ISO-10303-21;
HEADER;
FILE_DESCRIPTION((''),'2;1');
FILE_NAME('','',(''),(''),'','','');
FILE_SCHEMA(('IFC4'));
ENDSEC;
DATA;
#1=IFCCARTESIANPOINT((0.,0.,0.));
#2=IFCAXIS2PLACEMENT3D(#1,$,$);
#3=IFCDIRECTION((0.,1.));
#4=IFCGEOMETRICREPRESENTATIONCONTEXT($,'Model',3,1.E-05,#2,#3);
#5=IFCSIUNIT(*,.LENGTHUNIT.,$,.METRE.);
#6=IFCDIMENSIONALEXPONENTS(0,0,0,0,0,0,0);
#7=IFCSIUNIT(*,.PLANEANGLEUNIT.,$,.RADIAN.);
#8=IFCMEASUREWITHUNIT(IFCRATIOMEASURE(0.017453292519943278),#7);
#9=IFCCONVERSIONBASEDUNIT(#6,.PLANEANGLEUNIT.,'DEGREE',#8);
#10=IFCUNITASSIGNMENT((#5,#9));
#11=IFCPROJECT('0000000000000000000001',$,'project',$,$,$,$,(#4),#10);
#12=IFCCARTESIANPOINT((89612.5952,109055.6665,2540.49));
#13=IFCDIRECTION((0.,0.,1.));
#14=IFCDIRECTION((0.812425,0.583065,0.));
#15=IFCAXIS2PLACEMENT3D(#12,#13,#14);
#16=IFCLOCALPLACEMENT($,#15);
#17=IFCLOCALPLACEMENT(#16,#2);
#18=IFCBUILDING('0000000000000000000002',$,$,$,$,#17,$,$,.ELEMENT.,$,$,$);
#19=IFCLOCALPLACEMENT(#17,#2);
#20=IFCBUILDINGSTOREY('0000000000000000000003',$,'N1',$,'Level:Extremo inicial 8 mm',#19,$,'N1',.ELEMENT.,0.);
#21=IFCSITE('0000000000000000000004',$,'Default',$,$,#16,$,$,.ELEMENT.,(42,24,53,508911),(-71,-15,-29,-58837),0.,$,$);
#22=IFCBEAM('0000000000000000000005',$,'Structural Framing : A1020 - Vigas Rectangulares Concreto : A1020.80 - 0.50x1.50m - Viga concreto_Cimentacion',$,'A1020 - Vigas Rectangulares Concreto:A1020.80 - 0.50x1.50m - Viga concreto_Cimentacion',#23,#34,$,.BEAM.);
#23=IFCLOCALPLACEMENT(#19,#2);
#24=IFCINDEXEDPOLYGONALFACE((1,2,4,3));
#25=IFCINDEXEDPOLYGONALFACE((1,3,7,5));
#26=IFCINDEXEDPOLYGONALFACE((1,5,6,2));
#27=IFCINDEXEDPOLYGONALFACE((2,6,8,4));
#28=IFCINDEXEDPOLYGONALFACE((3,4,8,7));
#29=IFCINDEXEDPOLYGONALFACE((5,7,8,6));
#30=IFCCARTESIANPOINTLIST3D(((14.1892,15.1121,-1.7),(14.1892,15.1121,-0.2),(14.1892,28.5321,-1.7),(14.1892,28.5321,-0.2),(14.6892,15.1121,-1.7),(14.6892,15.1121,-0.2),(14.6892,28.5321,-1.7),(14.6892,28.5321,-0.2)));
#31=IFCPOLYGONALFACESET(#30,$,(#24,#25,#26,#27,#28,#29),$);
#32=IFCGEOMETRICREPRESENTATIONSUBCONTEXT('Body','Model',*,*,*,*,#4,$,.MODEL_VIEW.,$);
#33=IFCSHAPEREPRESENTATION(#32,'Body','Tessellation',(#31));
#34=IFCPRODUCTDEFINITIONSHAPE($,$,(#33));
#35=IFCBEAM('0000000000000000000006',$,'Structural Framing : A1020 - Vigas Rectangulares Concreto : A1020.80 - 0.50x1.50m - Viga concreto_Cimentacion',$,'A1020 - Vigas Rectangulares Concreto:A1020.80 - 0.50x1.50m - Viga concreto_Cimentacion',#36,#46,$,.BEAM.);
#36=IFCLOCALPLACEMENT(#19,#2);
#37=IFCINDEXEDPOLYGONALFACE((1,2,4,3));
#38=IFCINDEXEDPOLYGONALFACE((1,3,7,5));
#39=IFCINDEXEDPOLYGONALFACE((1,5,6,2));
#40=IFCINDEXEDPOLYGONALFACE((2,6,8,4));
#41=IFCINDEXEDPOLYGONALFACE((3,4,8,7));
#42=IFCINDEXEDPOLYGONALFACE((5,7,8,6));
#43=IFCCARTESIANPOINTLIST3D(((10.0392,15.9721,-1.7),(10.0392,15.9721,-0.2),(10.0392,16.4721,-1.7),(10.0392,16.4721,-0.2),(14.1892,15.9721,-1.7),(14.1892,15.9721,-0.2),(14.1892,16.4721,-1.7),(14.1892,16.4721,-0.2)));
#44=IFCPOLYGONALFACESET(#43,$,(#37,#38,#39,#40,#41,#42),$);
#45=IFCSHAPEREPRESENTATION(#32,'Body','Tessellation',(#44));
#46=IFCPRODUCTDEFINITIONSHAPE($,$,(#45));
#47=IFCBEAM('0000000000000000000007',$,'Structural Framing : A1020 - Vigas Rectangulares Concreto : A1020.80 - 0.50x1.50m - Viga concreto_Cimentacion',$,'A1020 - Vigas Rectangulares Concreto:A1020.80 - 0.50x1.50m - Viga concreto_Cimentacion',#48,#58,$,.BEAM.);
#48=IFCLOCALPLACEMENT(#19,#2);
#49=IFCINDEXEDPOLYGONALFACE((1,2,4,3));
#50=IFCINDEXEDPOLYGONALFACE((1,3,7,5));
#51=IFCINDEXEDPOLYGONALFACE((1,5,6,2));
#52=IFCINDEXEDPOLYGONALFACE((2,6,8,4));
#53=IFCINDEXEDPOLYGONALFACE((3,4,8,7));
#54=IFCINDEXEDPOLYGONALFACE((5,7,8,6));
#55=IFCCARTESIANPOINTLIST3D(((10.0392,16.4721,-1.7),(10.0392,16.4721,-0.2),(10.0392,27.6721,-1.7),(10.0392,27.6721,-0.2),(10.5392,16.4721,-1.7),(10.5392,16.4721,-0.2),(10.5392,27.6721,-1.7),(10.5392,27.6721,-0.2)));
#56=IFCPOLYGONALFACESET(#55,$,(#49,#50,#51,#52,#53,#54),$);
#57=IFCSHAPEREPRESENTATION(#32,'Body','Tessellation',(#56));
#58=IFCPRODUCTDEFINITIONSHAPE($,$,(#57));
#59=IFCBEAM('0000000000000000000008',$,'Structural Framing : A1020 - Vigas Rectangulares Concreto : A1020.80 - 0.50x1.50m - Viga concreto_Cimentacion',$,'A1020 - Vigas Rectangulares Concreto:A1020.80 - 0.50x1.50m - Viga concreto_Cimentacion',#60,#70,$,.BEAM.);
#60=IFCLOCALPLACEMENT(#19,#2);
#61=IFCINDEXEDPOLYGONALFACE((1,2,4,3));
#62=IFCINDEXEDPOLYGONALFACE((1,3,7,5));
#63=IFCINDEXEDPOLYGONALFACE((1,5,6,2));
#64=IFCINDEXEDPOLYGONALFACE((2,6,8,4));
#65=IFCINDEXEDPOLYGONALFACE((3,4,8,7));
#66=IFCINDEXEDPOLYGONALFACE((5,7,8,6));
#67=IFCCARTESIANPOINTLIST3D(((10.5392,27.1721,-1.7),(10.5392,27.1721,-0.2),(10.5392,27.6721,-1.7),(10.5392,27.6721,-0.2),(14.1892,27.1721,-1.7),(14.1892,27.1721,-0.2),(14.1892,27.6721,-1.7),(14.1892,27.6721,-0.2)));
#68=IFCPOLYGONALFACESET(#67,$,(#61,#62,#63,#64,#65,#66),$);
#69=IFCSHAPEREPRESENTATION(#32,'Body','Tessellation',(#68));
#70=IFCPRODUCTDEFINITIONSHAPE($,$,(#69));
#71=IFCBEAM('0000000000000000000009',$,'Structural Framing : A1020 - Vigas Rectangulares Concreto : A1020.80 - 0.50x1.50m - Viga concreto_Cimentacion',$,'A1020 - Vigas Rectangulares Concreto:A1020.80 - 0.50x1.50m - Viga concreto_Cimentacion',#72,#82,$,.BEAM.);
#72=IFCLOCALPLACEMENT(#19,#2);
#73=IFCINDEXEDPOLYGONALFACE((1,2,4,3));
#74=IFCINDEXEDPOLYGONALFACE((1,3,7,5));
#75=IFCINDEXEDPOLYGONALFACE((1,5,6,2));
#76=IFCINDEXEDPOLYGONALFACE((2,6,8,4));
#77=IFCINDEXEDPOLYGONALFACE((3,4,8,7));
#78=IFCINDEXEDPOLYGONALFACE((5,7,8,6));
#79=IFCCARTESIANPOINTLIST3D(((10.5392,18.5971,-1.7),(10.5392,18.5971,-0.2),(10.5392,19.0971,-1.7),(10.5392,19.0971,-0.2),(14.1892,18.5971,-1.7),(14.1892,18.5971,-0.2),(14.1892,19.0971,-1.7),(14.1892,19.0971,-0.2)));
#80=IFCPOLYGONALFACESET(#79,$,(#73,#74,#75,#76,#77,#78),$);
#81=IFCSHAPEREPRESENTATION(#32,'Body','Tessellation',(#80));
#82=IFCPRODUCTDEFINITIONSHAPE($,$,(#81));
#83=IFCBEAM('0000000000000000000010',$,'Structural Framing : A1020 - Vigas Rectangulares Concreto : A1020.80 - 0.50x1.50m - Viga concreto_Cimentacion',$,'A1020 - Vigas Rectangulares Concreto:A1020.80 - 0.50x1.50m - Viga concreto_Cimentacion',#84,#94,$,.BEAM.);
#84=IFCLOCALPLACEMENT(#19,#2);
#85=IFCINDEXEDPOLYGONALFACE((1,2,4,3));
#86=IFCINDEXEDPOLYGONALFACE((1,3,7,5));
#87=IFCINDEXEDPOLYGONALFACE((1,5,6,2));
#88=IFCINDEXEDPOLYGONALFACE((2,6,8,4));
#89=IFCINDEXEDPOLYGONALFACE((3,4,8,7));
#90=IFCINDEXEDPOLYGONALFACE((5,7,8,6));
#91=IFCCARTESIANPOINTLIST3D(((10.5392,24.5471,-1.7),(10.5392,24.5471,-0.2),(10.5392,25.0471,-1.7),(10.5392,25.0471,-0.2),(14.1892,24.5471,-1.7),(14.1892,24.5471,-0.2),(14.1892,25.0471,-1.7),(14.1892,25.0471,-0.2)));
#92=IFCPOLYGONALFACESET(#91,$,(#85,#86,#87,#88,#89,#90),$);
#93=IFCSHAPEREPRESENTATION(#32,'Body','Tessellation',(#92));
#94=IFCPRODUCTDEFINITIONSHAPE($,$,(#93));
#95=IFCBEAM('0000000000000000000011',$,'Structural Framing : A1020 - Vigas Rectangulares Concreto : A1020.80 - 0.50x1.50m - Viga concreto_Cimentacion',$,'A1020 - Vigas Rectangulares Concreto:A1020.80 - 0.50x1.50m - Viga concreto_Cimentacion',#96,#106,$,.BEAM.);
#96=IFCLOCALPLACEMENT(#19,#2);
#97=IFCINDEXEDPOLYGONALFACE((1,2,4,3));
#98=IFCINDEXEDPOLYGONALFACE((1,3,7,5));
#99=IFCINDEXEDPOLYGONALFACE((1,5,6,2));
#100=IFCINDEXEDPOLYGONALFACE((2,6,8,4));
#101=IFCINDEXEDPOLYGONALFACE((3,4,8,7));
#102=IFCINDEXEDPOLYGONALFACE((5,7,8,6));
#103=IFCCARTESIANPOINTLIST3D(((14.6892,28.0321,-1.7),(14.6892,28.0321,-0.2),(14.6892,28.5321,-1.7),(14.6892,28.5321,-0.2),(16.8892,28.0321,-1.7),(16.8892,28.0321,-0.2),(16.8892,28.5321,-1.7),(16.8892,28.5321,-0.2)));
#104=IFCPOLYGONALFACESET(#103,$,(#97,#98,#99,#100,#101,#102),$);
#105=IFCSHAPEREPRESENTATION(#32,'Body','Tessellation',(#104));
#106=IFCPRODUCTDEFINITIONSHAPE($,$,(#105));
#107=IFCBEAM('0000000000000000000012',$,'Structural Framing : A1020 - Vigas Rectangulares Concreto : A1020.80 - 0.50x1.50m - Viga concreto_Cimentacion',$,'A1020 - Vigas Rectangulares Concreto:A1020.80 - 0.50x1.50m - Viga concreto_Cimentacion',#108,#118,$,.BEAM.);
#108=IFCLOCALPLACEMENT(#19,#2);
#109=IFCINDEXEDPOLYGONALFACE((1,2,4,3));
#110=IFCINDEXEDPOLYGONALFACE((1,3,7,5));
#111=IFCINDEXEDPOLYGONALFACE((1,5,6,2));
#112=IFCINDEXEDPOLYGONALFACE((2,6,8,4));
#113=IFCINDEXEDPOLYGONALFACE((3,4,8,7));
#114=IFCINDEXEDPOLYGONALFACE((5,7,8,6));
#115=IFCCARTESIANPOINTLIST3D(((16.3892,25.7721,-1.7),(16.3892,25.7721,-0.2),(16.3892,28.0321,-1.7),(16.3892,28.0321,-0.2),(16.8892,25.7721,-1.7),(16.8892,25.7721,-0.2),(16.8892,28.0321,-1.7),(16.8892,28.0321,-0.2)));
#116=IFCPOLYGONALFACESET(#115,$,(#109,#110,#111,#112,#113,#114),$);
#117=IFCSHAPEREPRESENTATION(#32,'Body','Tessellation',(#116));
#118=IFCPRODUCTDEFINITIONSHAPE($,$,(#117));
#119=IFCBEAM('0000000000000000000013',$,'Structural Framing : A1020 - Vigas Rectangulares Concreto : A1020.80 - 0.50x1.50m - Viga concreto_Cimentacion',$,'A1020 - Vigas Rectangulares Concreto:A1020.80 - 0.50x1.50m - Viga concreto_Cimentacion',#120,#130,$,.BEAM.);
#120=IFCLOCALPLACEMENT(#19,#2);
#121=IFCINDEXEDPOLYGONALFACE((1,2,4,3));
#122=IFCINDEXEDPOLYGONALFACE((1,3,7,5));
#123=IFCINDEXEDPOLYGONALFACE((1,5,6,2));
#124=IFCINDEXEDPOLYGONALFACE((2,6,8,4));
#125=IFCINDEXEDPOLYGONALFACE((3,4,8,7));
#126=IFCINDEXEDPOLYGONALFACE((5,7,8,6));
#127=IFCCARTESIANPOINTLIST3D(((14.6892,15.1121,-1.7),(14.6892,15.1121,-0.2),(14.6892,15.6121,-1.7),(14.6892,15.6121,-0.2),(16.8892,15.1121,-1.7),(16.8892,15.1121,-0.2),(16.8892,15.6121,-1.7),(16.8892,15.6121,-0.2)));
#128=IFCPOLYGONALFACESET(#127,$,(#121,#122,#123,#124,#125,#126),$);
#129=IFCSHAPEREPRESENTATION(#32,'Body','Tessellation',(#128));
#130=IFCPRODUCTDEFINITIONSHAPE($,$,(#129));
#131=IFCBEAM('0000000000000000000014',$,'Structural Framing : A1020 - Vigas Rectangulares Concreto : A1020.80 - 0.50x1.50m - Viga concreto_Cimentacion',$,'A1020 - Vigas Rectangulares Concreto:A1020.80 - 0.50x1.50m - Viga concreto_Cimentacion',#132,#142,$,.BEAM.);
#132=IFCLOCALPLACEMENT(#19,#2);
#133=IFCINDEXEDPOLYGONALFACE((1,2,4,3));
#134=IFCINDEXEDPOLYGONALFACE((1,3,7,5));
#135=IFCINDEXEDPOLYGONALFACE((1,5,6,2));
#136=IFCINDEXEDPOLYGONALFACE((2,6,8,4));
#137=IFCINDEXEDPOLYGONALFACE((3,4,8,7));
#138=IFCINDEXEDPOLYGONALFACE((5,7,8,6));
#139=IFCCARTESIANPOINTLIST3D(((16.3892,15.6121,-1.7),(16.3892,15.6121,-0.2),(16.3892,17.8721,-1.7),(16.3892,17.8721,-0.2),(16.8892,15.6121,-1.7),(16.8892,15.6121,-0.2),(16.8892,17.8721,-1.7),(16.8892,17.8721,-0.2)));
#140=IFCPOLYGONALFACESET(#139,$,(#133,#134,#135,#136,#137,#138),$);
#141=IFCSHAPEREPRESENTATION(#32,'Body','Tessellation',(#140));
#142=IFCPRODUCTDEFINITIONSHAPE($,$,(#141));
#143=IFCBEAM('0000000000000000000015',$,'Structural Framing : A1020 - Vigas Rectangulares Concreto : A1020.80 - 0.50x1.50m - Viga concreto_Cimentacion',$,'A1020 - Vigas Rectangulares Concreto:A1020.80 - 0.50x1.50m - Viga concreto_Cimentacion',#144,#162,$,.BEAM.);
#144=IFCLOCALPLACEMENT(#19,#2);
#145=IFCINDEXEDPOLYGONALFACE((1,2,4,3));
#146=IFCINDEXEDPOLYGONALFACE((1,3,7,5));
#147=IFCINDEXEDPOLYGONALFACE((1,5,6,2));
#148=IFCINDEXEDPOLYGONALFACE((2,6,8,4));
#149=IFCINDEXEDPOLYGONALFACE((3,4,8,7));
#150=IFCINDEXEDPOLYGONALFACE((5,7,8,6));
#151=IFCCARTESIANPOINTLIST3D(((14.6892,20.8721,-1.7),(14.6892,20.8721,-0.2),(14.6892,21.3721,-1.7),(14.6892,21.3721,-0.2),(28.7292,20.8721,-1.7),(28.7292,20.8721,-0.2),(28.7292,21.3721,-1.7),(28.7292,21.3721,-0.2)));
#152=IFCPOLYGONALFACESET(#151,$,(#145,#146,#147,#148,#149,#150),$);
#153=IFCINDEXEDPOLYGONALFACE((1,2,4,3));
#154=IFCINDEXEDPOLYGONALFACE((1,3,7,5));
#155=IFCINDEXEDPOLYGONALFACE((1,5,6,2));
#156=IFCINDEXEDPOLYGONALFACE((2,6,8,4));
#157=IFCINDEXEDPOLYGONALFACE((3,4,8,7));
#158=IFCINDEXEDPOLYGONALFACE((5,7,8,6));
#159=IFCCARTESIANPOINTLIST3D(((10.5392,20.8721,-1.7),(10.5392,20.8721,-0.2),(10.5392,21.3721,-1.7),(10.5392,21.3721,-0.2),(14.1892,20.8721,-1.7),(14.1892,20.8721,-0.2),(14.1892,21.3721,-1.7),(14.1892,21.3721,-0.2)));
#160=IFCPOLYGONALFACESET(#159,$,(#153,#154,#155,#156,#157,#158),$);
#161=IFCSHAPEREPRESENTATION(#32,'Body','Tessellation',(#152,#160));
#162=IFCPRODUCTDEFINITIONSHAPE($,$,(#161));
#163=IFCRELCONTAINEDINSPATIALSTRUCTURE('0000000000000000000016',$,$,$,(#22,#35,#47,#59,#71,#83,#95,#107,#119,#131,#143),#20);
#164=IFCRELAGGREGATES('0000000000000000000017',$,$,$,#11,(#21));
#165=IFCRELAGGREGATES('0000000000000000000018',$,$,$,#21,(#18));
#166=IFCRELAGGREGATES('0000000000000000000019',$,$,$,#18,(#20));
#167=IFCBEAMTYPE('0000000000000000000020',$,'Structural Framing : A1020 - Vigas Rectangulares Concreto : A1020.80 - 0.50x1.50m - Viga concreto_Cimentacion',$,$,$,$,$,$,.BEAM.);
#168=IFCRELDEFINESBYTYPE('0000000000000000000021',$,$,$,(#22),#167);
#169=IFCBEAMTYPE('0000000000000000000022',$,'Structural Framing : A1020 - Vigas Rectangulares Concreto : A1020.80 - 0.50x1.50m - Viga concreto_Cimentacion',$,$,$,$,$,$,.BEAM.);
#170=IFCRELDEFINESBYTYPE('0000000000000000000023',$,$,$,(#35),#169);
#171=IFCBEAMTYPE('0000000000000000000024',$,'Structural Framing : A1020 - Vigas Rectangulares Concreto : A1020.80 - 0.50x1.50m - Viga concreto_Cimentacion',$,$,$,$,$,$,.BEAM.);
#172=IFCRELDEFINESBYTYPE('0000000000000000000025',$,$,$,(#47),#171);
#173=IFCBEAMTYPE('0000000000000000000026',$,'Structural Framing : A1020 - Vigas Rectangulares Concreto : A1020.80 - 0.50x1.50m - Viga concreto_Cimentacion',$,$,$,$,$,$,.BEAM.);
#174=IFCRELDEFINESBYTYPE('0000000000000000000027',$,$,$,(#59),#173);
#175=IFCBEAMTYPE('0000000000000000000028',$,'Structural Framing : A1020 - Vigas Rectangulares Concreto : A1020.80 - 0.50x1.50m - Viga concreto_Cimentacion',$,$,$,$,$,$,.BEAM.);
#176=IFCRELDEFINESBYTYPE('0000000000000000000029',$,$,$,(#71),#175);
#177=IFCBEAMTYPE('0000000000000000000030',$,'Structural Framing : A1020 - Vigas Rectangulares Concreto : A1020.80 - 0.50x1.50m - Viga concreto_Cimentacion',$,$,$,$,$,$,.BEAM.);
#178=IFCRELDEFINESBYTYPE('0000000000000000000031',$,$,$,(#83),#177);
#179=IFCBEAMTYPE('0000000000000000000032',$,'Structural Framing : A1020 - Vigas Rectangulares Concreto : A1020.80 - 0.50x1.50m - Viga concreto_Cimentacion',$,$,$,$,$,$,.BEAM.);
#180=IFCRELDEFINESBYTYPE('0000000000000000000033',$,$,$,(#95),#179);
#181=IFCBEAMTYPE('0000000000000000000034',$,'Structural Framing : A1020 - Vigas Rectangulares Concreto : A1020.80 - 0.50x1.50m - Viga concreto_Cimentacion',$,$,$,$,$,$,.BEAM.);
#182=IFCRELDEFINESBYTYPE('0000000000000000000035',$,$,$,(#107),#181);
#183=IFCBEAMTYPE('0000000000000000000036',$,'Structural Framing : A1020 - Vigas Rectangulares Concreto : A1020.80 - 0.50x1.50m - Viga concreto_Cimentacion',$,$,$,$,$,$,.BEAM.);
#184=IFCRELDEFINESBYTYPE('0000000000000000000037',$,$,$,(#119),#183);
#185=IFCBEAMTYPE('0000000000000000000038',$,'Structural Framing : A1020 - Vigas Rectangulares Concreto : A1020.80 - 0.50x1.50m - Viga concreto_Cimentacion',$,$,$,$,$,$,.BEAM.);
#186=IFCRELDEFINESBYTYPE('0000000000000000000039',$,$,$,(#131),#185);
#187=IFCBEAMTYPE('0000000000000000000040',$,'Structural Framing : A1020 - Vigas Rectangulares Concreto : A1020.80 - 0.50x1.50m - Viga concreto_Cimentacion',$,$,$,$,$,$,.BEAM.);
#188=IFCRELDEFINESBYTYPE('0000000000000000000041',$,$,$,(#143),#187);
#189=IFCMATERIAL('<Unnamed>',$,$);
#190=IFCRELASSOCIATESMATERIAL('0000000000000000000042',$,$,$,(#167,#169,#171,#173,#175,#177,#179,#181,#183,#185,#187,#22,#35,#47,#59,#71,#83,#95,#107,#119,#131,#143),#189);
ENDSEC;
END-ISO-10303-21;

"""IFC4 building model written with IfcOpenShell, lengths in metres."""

from ifc_helpers import new_model, entity, si_unit, converted_unit, direction, frame, frame_2d, origin, place, context, subcontext, project, spatial, polyline, segment, composite_curve, rectangle, outline, extrude, source, transform, mapped, material, material_profile, profile_set, profile_usage, type_object, type_shapes, element, save


model = new_model("IFC4")

# Units and contexts
model_context = context("Model", 3, precision=1e-05, world=origin(), true_north=direction((0.0, 1.0)))
body_context = subcontext(model_context, "Body", "Model", "MODEL_VIEW")
ifc_project = project(units=[si_unit("LENGTHUNIT", "METRE"), converted_unit("PLANEANGLEUNIT", "DEGREE", entity("IfcRatioMeasure", 0.017453292519943278), si_unit("PLANEANGLEUNIT", "RADIAN"), dimensions=[0, 0, 0, 0, 0, 0, 0])], contexts=[model_context])

# Site, building, storey
site_placement = place(None, frame((89612.5952, 109055.6665, 2540.49), z_axis=(0.0, 0.0, 1.0), x_axis=(0.812425, 0.583065, 0.0)))
site = spatial("IfcSite", under=ifc_project, at=site_placement, Name="Default", CompositionType="ELEMENT", RefLatitude=(42, 24, 53, 508911), RefLongitude=(-71, -15, -29, -58837), RefElevation=0.0)
building_placement = place(site_placement, origin())
building = spatial("IfcBuilding", under=site, at=building_placement, CompositionType="ELEMENT")
storey_placement = place(building_placement, origin())
storey = spatial("IfcBuildingStorey", under=building, at=storey_placement, Name="N1", ObjectType="Level:Extremo inicial 8 mm", LongName="N1", CompositionType="ELEMENT", Elevation=0.0)

# Beams
ifc_material_1 = material(Name="<Unnamed>")
ifc_material_profile_1 = material_profile(ifc_material_1, outline(composite_curve([segment(polyline([(-0.25, -0.75, 0.0), (-0.25, 0.75, 0.0)]), True, "CONTINUOUS"), segment(polyline([(-0.25, 0.75, 0.0), (0.25, 0.75, 0.0)]), True, "CONTINUOUS"), segment(polyline([(0.25, 0.75, 0.0), (0.25, -0.75, 0.0)]), True, "CONTINUOUS"), segment(polyline([(0.25, -0.75, 0.0), (-0.25, -0.75, 0.0)]), True, "CONTINUOUS")], self_intersect=False), kind="CURVE"), Name="A1020.80 - 0.50x1.50m - Viga concreto_Cimentacion")
ifc_material_profile_2 = material_profile(ifc_material_1, outline(composite_curve([segment(polyline([(6.1973, 0.25, 0.75), (6.1973, 0.25, -0.75)]), True, "CONTINUOUS"), segment(polyline([(6.1973, 0.25, -0.75), (-6.1973, 0.25, -0.75)]), True, "CONTINUOUS"), segment(polyline([(-6.1973, 0.25, -0.75), (-6.1973, 0.25, 0.75)]), True, "CONTINUOUS"), segment(polyline([(-6.1973, 0.25, 0.75), (6.1973, 0.25, 0.75)]), True, "CONTINUOUS")], self_intersect=False), kind="CURVE"), Name="A1020.80 - 0.50x1.50m - Viga concreto_Cimentacion")
ifc_profile_set_1 = profile_set([ifc_material_profile_1, ifc_material_profile_2], Name="A1020.80 - 0.50x1.50m - Viga concreto_Cimentacion")
ifc_profile_usage_1 = profile_usage(ifc_profile_set_1, cardinal=8)
beam_type_1 = type_object("IfcBeamType", Name="Structural Framing : A1020 - Vigas Rectangulares Concreto : A1020.80 - 0.50x1.50m - Viga concreto_Cimentacion", PredefinedType="BEAM", material=ifc_profile_set_1)
shared_shape_1 = source(origin(), body_context, "Body", "SweptSolid", [
    extrude(rectangle(XDim=1.5, YDim=0.5, at=frame_2d((0.0, 0.0), x_axis=(0.0, 1.0))), frame((14.4392, 28.5321, -0.95), z_axis=(0.0, -1.0, 0.0), x_axis=(-1.0, 0.0, 0.0)), (0.0, 0.0, 1.0), 13.42),
])
type_shapes(beam_type_1, [shared_shape_1])
beam_1_placement = place(storey_placement, origin())
element("IfcBeam", 1, at=beam_1_placement, inside=storey, type_object=beam_type_1, material=ifc_profile_usage_1, Name="Structural Framing : A1020 - Vigas Rectangulares Concreto : A1020.80 - 0.50x1.50m - Viga concreto_Cimentacion", ObjectType="A1020 - Vigas Rectangulares Concreto:A1020.80 - 0.50x1.50m - Viga concreto_Cimentacion", PredefinedType="BEAM", context=body_context, shape_type="MappedRepresentation", body=[
    mapped(shared_shape_1, transform((0.0, 0.0, 0.0), scale=1.0)),
])
ifc_profile_usage_2 = profile_usage(ifc_profile_set_1, cardinal=8)
beam_type_2 = type_object("IfcBeamType", Name="Structural Framing : A1020 - Vigas Rectangulares Concreto : A1020.80 - 0.50x1.50m - Viga concreto_Cimentacion", PredefinedType="BEAM", material=ifc_profile_set_1)
shared_shape_2 = source(origin(), body_context, "Body", "SweptSolid", [
    extrude(rectangle(XDim=1.5, YDim=0.5, at=frame_2d((0.0, 0.0), x_axis=(1.0, 0.0))), frame((14.1892, 16.2221, -0.95), z_axis=(-1.0, 0.0, 0.0), x_axis=(0.0, 0.0, -1.0)), (0.0, 0.0, 1.0), 4.15),
])
type_shapes(beam_type_2, [shared_shape_2])
beam_2_placement = place(storey_placement, origin())
element("IfcBeam", 2, at=beam_2_placement, inside=storey, type_object=beam_type_2, material=ifc_profile_usage_2, Name="Structural Framing : A1020 - Vigas Rectangulares Concreto : A1020.80 - 0.50x1.50m - Viga concreto_Cimentacion", ObjectType="A1020 - Vigas Rectangulares Concreto:A1020.80 - 0.50x1.50m - Viga concreto_Cimentacion", PredefinedType="BEAM", context=body_context, shape_type="MappedRepresentation", body=[
    mapped(shared_shape_2, transform((0.0, 0.0, 0.0), scale=1.0)),
])
ifc_profile_usage_3 = profile_usage(ifc_profile_set_1, cardinal=8)
beam_type_3 = type_object("IfcBeamType", Name="Structural Framing : A1020 - Vigas Rectangulares Concreto : A1020.80 - 0.50x1.50m - Viga concreto_Cimentacion", PredefinedType="BEAM", material=ifc_profile_set_1)
shared_shape_3 = source(origin(), body_context, "Body", "SweptSolid", [
    extrude(rectangle(XDim=1.5, YDim=0.5, at=frame_2d((0.0, 0.0), x_axis=(0.0, 1.0))), frame((10.2892, 16.4721, -0.95), z_axis=(0.0, 1.0, 0.0), x_axis=(-1.0, 0.0, 0.0)), (0.0, 0.0, 1.0), 11.2),
])
type_shapes(beam_type_3, [shared_shape_3])
beam_3_placement = place(storey_placement, origin())
element("IfcBeam", 3, at=beam_3_placement, inside=storey, type_object=beam_type_3, material=ifc_profile_usage_3, Name="Structural Framing : A1020 - Vigas Rectangulares Concreto : A1020.80 - 0.50x1.50m - Viga concreto_Cimentacion", ObjectType="A1020 - Vigas Rectangulares Concreto:A1020.80 - 0.50x1.50m - Viga concreto_Cimentacion", PredefinedType="BEAM", context=body_context, shape_type="MappedRepresentation", body=[
    mapped(shared_shape_3, transform((0.0, 0.0, 0.0), scale=1.0)),
])
ifc_profile_usage_4 = profile_usage(ifc_profile_set_1, cardinal=8)
beam_type_4 = type_object("IfcBeamType", Name="Structural Framing : A1020 - Vigas Rectangulares Concreto : A1020.80 - 0.50x1.50m - Viga concreto_Cimentacion", PredefinedType="BEAM", material=ifc_profile_set_1)
shared_shape_4 = source(origin(), body_context, "Body", "SweptSolid", [
    extrude(rectangle(XDim=1.5, YDim=0.5, at=frame_2d((0.0, 0.0), x_axis=(1.0, 0.0))), frame((10.5392, 27.4221, -0.95), z_axis=(1.0, 0.0, 0.0), x_axis=(0.0, 0.0, -1.0)), (0.0, 0.0, 1.0), 3.65),
])
type_shapes(beam_type_4, [shared_shape_4])
beam_4_placement = place(storey_placement, origin())
element("IfcBeam", 4, at=beam_4_placement, inside=storey, type_object=beam_type_4, material=ifc_profile_usage_4, Name="Structural Framing : A1020 - Vigas Rectangulares Concreto : A1020.80 - 0.50x1.50m - Viga concreto_Cimentacion", ObjectType="A1020 - Vigas Rectangulares Concreto:A1020.80 - 0.50x1.50m - Viga concreto_Cimentacion", PredefinedType="BEAM", context=body_context, shape_type="MappedRepresentation", body=[
    mapped(shared_shape_4, transform((0.0, 0.0, 0.0), scale=1.0)),
])
ifc_profile_usage_5 = profile_usage(ifc_profile_set_1, cardinal=8)
beam_type_5 = type_object("IfcBeamType", Name="Structural Framing : A1020 - Vigas Rectangulares Concreto : A1020.80 - 0.50x1.50m - Viga concreto_Cimentacion", PredefinedType="BEAM", material=ifc_profile_set_1)
shared_shape_5 = source(origin(), body_context, "Body", "SweptSolid", [
    extrude(rectangle(XDim=1.5, YDim=0.5, at=frame_2d((0.0, 0.0), x_axis=(1.0, 0.0))), frame((10.5392, 18.8471, -0.95), z_axis=(1.0, 0.0, 0.0), x_axis=(0.0, 0.0, -1.0)), (0.0, 0.0, 1.0), 3.65),
])
type_shapes(beam_type_5, [shared_shape_5])
beam_5_placement = place(storey_placement, origin())
element("IfcBeam", 5, at=beam_5_placement, inside=storey, type_object=beam_type_5, material=ifc_profile_usage_5, Name="Structural Framing : A1020 - Vigas Rectangulares Concreto : A1020.80 - 0.50x1.50m - Viga concreto_Cimentacion", ObjectType="A1020 - Vigas Rectangulares Concreto:A1020.80 - 0.50x1.50m - Viga concreto_Cimentacion", PredefinedType="BEAM", context=body_context, shape_type="MappedRepresentation", body=[
    mapped(shared_shape_5, transform((0.0, 0.0, 0.0), scale=1.0)),
])
ifc_profile_usage_6 = profile_usage(ifc_profile_set_1, cardinal=8)
beam_type_6 = type_object("IfcBeamType", Name="Structural Framing : A1020 - Vigas Rectangulares Concreto : A1020.80 - 0.50x1.50m - Viga concreto_Cimentacion", PredefinedType="BEAM", material=ifc_profile_set_1)
shared_shape_6 = source(origin(), body_context, "Body", "SweptSolid", [
    extrude(rectangle(XDim=1.5, YDim=0.5, at=frame_2d((0.0, 0.0), x_axis=(1.0, 0.0))), frame((10.5392, 24.7971, -0.95), z_axis=(1.0, 0.0, 0.0), x_axis=(0.0, 0.0, -1.0)), (0.0, 0.0, 1.0), 3.65),
])
type_shapes(beam_type_6, [shared_shape_6])
beam_6_placement = place(storey_placement, origin())
element("IfcBeam", 6, at=beam_6_placement, inside=storey, type_object=beam_type_6, material=ifc_profile_usage_6, Name="Structural Framing : A1020 - Vigas Rectangulares Concreto : A1020.80 - 0.50x1.50m - Viga concreto_Cimentacion", ObjectType="A1020 - Vigas Rectangulares Concreto:A1020.80 - 0.50x1.50m - Viga concreto_Cimentacion", PredefinedType="BEAM", context=body_context, shape_type="MappedRepresentation", body=[
    mapped(shared_shape_6, transform((0.0, 0.0, 0.0), scale=1.0)),
])
ifc_profile_usage_7 = profile_usage(ifc_profile_set_1, cardinal=8)
beam_type_7 = type_object("IfcBeamType", Name="Structural Framing : A1020 - Vigas Rectangulares Concreto : A1020.80 - 0.50x1.50m - Viga concreto_Cimentacion", PredefinedType="BEAM", material=ifc_profile_set_1)
shared_shape_7 = source(origin(), body_context, "Body", "SweptSolid", [
    extrude(rectangle(XDim=1.5, YDim=0.5, at=frame_2d((0.0, 0.0), x_axis=(1.0, 0.0))), frame((14.6892, 28.2821, -0.95), z_axis=(1.0, 0.0, 0.0), x_axis=(0.0, 0.0, -1.0)), (0.0, 0.0, 1.0), 2.2),
])
type_shapes(beam_type_7, [shared_shape_7])
beam_7_placement = place(storey_placement, origin())
element("IfcBeam", 7, at=beam_7_placement, inside=storey, type_object=beam_type_7, material=ifc_profile_usage_7, Name="Structural Framing : A1020 - Vigas Rectangulares Concreto : A1020.80 - 0.50x1.50m - Viga concreto_Cimentacion", ObjectType="A1020 - Vigas Rectangulares Concreto:A1020.80 - 0.50x1.50m - Viga concreto_Cimentacion", PredefinedType="BEAM", context=body_context, shape_type="MappedRepresentation", body=[
    mapped(shared_shape_7, transform((0.0, 0.0, 0.0), scale=1.0)),
])
ifc_profile_usage_8 = profile_usage(ifc_profile_set_1, cardinal=8)
beam_type_8 = type_object("IfcBeamType", Name="Structural Framing : A1020 - Vigas Rectangulares Concreto : A1020.80 - 0.50x1.50m - Viga concreto_Cimentacion", PredefinedType="BEAM", material=ifc_profile_set_1)
shared_shape_8 = source(origin(), body_context, "Body", "SweptSolid", [
    extrude(rectangle(XDim=1.5, YDim=0.5, at=frame_2d((0.0, 0.0), x_axis=(0.0, 1.0))), frame((16.6392, 25.7721, -0.95), z_axis=(0.0, 1.0, 0.0), x_axis=(-1.0, 0.0, 0.0)), (0.0, 0.0, 1.0), 2.26),
])
type_shapes(beam_type_8, [shared_shape_8])
beam_8_placement = place(storey_placement, origin())
element("IfcBeam", 8, at=beam_8_placement, inside=storey, type_object=beam_type_8, material=ifc_profile_usage_8, Name="Structural Framing : A1020 - Vigas Rectangulares Concreto : A1020.80 - 0.50x1.50m - Viga concreto_Cimentacion", ObjectType="A1020 - Vigas Rectangulares Concreto:A1020.80 - 0.50x1.50m - Viga concreto_Cimentacion", PredefinedType="BEAM", context=body_context, shape_type="MappedRepresentation", body=[
    mapped(shared_shape_8, transform((0.0, 0.0, 0.0), scale=1.0)),
])
ifc_profile_usage_9 = profile_usage(ifc_profile_set_1, cardinal=8)
beam_type_9 = type_object("IfcBeamType", Name="Structural Framing : A1020 - Vigas Rectangulares Concreto : A1020.80 - 0.50x1.50m - Viga concreto_Cimentacion", PredefinedType="BEAM", material=ifc_profile_set_1)
shared_shape_9 = source(origin(), body_context, "Body", "SweptSolid", [
    extrude(rectangle(XDim=1.5, YDim=0.5, at=frame_2d((0.0, 0.0), x_axis=(1.0, 0.0))), frame((14.6892, 15.3621, -0.95), z_axis=(1.0, 0.0, 0.0), x_axis=(0.0, 0.0, -1.0)), (0.0, 0.0, 1.0), 2.2),
])
type_shapes(beam_type_9, [shared_shape_9])
beam_9_placement = place(storey_placement, origin())
element("IfcBeam", 9, at=beam_9_placement, inside=storey, type_object=beam_type_9, material=ifc_profile_usage_9, Name="Structural Framing : A1020 - Vigas Rectangulares Concreto : A1020.80 - 0.50x1.50m - Viga concreto_Cimentacion", ObjectType="A1020 - Vigas Rectangulares Concreto:A1020.80 - 0.50x1.50m - Viga concreto_Cimentacion", PredefinedType="BEAM", context=body_context, shape_type="MappedRepresentation", body=[
    mapped(shared_shape_9, transform((0.0, 0.0, 0.0), scale=1.0)),
])
ifc_profile_usage_10 = profile_usage(ifc_profile_set_1, cardinal=8)
beam_type_10 = type_object("IfcBeamType", Name="Structural Framing : A1020 - Vigas Rectangulares Concreto : A1020.80 - 0.50x1.50m - Viga concreto_Cimentacion", PredefinedType="BEAM", material=ifc_profile_set_1)
shared_shape_10 = source(origin(), body_context, "Body", "SweptSolid", [
    extrude(rectangle(XDim=1.5, YDim=0.5, at=frame_2d((0.0, 0.0), x_axis=(0.0, 1.0))), frame((16.6392, 15.6121, -0.95), z_axis=(0.0, 1.0, 0.0), x_axis=(-1.0, 0.0, 0.0)), (0.0, 0.0, 1.0), 2.26),
])
type_shapes(beam_type_10, [shared_shape_10])
beam_10_placement = place(storey_placement, origin())
element("IfcBeam", 10, at=beam_10_placement, inside=storey, type_object=beam_type_10, material=ifc_profile_usage_10, Name="Structural Framing : A1020 - Vigas Rectangulares Concreto : A1020.80 - 0.50x1.50m - Viga concreto_Cimentacion", ObjectType="A1020 - Vigas Rectangulares Concreto:A1020.80 - 0.50x1.50m - Viga concreto_Cimentacion", PredefinedType="BEAM", context=body_context, shape_type="MappedRepresentation", body=[
    mapped(shared_shape_10, transform((0.0, 0.0, 0.0), scale=1.0)),
])
ifc_profile_usage_11 = profile_usage(ifc_profile_set_1, cardinal=8)
beam_type_11 = type_object("IfcBeamType", Name="Structural Framing : A1020 - Vigas Rectangulares Concreto : A1020.80 - 0.50x1.50m - Viga concreto_Cimentacion", PredefinedType="BEAM", material=ifc_profile_set_1)
shared_shape_11 = source(origin(), body_context, "Body", "SweptSolid", [
    extrude(rectangle(XDim=1.5, YDim=0.5, at=frame_2d((0.0, 0.0), x_axis=(1.0, 0.0))), frame((14.6892, 21.1221, -0.95), z_axis=(1.0, 0.0, 0.0), x_axis=(0.0, 0.0, -1.0)), (0.0, 0.0, 1.0), 14.04),
    extrude(rectangle(XDim=1.5, YDim=0.5, at=frame_2d((0.0, 0.0), x_axis=(1.0, 0.0))), frame((10.5392, 21.1221, -0.95), z_axis=(1.0, 0.0, 0.0), x_axis=(0.0, 0.0, -1.0)), (0.0, 0.0, 1.0), 3.65),
])
type_shapes(beam_type_11, [shared_shape_11])
beam_11_placement = place(storey_placement, origin())
element("IfcBeam", 11, at=beam_11_placement, inside=storey, type_object=beam_type_11, material=ifc_profile_usage_11, Name="Structural Framing : A1020 - Vigas Rectangulares Concreto : A1020.80 - 0.50x1.50m - Viga concreto_Cimentacion", ObjectType="A1020 - Vigas Rectangulares Concreto:A1020.80 - 0.50x1.50m - Viga concreto_Cimentacion", PredefinedType="BEAM", context=body_context, shape_type="MappedRepresentation", body=[
    mapped(shared_shape_11, transform((0.0, 0.0, 0.0), scale=1.0)),
])

save(model, "model.ifc")
